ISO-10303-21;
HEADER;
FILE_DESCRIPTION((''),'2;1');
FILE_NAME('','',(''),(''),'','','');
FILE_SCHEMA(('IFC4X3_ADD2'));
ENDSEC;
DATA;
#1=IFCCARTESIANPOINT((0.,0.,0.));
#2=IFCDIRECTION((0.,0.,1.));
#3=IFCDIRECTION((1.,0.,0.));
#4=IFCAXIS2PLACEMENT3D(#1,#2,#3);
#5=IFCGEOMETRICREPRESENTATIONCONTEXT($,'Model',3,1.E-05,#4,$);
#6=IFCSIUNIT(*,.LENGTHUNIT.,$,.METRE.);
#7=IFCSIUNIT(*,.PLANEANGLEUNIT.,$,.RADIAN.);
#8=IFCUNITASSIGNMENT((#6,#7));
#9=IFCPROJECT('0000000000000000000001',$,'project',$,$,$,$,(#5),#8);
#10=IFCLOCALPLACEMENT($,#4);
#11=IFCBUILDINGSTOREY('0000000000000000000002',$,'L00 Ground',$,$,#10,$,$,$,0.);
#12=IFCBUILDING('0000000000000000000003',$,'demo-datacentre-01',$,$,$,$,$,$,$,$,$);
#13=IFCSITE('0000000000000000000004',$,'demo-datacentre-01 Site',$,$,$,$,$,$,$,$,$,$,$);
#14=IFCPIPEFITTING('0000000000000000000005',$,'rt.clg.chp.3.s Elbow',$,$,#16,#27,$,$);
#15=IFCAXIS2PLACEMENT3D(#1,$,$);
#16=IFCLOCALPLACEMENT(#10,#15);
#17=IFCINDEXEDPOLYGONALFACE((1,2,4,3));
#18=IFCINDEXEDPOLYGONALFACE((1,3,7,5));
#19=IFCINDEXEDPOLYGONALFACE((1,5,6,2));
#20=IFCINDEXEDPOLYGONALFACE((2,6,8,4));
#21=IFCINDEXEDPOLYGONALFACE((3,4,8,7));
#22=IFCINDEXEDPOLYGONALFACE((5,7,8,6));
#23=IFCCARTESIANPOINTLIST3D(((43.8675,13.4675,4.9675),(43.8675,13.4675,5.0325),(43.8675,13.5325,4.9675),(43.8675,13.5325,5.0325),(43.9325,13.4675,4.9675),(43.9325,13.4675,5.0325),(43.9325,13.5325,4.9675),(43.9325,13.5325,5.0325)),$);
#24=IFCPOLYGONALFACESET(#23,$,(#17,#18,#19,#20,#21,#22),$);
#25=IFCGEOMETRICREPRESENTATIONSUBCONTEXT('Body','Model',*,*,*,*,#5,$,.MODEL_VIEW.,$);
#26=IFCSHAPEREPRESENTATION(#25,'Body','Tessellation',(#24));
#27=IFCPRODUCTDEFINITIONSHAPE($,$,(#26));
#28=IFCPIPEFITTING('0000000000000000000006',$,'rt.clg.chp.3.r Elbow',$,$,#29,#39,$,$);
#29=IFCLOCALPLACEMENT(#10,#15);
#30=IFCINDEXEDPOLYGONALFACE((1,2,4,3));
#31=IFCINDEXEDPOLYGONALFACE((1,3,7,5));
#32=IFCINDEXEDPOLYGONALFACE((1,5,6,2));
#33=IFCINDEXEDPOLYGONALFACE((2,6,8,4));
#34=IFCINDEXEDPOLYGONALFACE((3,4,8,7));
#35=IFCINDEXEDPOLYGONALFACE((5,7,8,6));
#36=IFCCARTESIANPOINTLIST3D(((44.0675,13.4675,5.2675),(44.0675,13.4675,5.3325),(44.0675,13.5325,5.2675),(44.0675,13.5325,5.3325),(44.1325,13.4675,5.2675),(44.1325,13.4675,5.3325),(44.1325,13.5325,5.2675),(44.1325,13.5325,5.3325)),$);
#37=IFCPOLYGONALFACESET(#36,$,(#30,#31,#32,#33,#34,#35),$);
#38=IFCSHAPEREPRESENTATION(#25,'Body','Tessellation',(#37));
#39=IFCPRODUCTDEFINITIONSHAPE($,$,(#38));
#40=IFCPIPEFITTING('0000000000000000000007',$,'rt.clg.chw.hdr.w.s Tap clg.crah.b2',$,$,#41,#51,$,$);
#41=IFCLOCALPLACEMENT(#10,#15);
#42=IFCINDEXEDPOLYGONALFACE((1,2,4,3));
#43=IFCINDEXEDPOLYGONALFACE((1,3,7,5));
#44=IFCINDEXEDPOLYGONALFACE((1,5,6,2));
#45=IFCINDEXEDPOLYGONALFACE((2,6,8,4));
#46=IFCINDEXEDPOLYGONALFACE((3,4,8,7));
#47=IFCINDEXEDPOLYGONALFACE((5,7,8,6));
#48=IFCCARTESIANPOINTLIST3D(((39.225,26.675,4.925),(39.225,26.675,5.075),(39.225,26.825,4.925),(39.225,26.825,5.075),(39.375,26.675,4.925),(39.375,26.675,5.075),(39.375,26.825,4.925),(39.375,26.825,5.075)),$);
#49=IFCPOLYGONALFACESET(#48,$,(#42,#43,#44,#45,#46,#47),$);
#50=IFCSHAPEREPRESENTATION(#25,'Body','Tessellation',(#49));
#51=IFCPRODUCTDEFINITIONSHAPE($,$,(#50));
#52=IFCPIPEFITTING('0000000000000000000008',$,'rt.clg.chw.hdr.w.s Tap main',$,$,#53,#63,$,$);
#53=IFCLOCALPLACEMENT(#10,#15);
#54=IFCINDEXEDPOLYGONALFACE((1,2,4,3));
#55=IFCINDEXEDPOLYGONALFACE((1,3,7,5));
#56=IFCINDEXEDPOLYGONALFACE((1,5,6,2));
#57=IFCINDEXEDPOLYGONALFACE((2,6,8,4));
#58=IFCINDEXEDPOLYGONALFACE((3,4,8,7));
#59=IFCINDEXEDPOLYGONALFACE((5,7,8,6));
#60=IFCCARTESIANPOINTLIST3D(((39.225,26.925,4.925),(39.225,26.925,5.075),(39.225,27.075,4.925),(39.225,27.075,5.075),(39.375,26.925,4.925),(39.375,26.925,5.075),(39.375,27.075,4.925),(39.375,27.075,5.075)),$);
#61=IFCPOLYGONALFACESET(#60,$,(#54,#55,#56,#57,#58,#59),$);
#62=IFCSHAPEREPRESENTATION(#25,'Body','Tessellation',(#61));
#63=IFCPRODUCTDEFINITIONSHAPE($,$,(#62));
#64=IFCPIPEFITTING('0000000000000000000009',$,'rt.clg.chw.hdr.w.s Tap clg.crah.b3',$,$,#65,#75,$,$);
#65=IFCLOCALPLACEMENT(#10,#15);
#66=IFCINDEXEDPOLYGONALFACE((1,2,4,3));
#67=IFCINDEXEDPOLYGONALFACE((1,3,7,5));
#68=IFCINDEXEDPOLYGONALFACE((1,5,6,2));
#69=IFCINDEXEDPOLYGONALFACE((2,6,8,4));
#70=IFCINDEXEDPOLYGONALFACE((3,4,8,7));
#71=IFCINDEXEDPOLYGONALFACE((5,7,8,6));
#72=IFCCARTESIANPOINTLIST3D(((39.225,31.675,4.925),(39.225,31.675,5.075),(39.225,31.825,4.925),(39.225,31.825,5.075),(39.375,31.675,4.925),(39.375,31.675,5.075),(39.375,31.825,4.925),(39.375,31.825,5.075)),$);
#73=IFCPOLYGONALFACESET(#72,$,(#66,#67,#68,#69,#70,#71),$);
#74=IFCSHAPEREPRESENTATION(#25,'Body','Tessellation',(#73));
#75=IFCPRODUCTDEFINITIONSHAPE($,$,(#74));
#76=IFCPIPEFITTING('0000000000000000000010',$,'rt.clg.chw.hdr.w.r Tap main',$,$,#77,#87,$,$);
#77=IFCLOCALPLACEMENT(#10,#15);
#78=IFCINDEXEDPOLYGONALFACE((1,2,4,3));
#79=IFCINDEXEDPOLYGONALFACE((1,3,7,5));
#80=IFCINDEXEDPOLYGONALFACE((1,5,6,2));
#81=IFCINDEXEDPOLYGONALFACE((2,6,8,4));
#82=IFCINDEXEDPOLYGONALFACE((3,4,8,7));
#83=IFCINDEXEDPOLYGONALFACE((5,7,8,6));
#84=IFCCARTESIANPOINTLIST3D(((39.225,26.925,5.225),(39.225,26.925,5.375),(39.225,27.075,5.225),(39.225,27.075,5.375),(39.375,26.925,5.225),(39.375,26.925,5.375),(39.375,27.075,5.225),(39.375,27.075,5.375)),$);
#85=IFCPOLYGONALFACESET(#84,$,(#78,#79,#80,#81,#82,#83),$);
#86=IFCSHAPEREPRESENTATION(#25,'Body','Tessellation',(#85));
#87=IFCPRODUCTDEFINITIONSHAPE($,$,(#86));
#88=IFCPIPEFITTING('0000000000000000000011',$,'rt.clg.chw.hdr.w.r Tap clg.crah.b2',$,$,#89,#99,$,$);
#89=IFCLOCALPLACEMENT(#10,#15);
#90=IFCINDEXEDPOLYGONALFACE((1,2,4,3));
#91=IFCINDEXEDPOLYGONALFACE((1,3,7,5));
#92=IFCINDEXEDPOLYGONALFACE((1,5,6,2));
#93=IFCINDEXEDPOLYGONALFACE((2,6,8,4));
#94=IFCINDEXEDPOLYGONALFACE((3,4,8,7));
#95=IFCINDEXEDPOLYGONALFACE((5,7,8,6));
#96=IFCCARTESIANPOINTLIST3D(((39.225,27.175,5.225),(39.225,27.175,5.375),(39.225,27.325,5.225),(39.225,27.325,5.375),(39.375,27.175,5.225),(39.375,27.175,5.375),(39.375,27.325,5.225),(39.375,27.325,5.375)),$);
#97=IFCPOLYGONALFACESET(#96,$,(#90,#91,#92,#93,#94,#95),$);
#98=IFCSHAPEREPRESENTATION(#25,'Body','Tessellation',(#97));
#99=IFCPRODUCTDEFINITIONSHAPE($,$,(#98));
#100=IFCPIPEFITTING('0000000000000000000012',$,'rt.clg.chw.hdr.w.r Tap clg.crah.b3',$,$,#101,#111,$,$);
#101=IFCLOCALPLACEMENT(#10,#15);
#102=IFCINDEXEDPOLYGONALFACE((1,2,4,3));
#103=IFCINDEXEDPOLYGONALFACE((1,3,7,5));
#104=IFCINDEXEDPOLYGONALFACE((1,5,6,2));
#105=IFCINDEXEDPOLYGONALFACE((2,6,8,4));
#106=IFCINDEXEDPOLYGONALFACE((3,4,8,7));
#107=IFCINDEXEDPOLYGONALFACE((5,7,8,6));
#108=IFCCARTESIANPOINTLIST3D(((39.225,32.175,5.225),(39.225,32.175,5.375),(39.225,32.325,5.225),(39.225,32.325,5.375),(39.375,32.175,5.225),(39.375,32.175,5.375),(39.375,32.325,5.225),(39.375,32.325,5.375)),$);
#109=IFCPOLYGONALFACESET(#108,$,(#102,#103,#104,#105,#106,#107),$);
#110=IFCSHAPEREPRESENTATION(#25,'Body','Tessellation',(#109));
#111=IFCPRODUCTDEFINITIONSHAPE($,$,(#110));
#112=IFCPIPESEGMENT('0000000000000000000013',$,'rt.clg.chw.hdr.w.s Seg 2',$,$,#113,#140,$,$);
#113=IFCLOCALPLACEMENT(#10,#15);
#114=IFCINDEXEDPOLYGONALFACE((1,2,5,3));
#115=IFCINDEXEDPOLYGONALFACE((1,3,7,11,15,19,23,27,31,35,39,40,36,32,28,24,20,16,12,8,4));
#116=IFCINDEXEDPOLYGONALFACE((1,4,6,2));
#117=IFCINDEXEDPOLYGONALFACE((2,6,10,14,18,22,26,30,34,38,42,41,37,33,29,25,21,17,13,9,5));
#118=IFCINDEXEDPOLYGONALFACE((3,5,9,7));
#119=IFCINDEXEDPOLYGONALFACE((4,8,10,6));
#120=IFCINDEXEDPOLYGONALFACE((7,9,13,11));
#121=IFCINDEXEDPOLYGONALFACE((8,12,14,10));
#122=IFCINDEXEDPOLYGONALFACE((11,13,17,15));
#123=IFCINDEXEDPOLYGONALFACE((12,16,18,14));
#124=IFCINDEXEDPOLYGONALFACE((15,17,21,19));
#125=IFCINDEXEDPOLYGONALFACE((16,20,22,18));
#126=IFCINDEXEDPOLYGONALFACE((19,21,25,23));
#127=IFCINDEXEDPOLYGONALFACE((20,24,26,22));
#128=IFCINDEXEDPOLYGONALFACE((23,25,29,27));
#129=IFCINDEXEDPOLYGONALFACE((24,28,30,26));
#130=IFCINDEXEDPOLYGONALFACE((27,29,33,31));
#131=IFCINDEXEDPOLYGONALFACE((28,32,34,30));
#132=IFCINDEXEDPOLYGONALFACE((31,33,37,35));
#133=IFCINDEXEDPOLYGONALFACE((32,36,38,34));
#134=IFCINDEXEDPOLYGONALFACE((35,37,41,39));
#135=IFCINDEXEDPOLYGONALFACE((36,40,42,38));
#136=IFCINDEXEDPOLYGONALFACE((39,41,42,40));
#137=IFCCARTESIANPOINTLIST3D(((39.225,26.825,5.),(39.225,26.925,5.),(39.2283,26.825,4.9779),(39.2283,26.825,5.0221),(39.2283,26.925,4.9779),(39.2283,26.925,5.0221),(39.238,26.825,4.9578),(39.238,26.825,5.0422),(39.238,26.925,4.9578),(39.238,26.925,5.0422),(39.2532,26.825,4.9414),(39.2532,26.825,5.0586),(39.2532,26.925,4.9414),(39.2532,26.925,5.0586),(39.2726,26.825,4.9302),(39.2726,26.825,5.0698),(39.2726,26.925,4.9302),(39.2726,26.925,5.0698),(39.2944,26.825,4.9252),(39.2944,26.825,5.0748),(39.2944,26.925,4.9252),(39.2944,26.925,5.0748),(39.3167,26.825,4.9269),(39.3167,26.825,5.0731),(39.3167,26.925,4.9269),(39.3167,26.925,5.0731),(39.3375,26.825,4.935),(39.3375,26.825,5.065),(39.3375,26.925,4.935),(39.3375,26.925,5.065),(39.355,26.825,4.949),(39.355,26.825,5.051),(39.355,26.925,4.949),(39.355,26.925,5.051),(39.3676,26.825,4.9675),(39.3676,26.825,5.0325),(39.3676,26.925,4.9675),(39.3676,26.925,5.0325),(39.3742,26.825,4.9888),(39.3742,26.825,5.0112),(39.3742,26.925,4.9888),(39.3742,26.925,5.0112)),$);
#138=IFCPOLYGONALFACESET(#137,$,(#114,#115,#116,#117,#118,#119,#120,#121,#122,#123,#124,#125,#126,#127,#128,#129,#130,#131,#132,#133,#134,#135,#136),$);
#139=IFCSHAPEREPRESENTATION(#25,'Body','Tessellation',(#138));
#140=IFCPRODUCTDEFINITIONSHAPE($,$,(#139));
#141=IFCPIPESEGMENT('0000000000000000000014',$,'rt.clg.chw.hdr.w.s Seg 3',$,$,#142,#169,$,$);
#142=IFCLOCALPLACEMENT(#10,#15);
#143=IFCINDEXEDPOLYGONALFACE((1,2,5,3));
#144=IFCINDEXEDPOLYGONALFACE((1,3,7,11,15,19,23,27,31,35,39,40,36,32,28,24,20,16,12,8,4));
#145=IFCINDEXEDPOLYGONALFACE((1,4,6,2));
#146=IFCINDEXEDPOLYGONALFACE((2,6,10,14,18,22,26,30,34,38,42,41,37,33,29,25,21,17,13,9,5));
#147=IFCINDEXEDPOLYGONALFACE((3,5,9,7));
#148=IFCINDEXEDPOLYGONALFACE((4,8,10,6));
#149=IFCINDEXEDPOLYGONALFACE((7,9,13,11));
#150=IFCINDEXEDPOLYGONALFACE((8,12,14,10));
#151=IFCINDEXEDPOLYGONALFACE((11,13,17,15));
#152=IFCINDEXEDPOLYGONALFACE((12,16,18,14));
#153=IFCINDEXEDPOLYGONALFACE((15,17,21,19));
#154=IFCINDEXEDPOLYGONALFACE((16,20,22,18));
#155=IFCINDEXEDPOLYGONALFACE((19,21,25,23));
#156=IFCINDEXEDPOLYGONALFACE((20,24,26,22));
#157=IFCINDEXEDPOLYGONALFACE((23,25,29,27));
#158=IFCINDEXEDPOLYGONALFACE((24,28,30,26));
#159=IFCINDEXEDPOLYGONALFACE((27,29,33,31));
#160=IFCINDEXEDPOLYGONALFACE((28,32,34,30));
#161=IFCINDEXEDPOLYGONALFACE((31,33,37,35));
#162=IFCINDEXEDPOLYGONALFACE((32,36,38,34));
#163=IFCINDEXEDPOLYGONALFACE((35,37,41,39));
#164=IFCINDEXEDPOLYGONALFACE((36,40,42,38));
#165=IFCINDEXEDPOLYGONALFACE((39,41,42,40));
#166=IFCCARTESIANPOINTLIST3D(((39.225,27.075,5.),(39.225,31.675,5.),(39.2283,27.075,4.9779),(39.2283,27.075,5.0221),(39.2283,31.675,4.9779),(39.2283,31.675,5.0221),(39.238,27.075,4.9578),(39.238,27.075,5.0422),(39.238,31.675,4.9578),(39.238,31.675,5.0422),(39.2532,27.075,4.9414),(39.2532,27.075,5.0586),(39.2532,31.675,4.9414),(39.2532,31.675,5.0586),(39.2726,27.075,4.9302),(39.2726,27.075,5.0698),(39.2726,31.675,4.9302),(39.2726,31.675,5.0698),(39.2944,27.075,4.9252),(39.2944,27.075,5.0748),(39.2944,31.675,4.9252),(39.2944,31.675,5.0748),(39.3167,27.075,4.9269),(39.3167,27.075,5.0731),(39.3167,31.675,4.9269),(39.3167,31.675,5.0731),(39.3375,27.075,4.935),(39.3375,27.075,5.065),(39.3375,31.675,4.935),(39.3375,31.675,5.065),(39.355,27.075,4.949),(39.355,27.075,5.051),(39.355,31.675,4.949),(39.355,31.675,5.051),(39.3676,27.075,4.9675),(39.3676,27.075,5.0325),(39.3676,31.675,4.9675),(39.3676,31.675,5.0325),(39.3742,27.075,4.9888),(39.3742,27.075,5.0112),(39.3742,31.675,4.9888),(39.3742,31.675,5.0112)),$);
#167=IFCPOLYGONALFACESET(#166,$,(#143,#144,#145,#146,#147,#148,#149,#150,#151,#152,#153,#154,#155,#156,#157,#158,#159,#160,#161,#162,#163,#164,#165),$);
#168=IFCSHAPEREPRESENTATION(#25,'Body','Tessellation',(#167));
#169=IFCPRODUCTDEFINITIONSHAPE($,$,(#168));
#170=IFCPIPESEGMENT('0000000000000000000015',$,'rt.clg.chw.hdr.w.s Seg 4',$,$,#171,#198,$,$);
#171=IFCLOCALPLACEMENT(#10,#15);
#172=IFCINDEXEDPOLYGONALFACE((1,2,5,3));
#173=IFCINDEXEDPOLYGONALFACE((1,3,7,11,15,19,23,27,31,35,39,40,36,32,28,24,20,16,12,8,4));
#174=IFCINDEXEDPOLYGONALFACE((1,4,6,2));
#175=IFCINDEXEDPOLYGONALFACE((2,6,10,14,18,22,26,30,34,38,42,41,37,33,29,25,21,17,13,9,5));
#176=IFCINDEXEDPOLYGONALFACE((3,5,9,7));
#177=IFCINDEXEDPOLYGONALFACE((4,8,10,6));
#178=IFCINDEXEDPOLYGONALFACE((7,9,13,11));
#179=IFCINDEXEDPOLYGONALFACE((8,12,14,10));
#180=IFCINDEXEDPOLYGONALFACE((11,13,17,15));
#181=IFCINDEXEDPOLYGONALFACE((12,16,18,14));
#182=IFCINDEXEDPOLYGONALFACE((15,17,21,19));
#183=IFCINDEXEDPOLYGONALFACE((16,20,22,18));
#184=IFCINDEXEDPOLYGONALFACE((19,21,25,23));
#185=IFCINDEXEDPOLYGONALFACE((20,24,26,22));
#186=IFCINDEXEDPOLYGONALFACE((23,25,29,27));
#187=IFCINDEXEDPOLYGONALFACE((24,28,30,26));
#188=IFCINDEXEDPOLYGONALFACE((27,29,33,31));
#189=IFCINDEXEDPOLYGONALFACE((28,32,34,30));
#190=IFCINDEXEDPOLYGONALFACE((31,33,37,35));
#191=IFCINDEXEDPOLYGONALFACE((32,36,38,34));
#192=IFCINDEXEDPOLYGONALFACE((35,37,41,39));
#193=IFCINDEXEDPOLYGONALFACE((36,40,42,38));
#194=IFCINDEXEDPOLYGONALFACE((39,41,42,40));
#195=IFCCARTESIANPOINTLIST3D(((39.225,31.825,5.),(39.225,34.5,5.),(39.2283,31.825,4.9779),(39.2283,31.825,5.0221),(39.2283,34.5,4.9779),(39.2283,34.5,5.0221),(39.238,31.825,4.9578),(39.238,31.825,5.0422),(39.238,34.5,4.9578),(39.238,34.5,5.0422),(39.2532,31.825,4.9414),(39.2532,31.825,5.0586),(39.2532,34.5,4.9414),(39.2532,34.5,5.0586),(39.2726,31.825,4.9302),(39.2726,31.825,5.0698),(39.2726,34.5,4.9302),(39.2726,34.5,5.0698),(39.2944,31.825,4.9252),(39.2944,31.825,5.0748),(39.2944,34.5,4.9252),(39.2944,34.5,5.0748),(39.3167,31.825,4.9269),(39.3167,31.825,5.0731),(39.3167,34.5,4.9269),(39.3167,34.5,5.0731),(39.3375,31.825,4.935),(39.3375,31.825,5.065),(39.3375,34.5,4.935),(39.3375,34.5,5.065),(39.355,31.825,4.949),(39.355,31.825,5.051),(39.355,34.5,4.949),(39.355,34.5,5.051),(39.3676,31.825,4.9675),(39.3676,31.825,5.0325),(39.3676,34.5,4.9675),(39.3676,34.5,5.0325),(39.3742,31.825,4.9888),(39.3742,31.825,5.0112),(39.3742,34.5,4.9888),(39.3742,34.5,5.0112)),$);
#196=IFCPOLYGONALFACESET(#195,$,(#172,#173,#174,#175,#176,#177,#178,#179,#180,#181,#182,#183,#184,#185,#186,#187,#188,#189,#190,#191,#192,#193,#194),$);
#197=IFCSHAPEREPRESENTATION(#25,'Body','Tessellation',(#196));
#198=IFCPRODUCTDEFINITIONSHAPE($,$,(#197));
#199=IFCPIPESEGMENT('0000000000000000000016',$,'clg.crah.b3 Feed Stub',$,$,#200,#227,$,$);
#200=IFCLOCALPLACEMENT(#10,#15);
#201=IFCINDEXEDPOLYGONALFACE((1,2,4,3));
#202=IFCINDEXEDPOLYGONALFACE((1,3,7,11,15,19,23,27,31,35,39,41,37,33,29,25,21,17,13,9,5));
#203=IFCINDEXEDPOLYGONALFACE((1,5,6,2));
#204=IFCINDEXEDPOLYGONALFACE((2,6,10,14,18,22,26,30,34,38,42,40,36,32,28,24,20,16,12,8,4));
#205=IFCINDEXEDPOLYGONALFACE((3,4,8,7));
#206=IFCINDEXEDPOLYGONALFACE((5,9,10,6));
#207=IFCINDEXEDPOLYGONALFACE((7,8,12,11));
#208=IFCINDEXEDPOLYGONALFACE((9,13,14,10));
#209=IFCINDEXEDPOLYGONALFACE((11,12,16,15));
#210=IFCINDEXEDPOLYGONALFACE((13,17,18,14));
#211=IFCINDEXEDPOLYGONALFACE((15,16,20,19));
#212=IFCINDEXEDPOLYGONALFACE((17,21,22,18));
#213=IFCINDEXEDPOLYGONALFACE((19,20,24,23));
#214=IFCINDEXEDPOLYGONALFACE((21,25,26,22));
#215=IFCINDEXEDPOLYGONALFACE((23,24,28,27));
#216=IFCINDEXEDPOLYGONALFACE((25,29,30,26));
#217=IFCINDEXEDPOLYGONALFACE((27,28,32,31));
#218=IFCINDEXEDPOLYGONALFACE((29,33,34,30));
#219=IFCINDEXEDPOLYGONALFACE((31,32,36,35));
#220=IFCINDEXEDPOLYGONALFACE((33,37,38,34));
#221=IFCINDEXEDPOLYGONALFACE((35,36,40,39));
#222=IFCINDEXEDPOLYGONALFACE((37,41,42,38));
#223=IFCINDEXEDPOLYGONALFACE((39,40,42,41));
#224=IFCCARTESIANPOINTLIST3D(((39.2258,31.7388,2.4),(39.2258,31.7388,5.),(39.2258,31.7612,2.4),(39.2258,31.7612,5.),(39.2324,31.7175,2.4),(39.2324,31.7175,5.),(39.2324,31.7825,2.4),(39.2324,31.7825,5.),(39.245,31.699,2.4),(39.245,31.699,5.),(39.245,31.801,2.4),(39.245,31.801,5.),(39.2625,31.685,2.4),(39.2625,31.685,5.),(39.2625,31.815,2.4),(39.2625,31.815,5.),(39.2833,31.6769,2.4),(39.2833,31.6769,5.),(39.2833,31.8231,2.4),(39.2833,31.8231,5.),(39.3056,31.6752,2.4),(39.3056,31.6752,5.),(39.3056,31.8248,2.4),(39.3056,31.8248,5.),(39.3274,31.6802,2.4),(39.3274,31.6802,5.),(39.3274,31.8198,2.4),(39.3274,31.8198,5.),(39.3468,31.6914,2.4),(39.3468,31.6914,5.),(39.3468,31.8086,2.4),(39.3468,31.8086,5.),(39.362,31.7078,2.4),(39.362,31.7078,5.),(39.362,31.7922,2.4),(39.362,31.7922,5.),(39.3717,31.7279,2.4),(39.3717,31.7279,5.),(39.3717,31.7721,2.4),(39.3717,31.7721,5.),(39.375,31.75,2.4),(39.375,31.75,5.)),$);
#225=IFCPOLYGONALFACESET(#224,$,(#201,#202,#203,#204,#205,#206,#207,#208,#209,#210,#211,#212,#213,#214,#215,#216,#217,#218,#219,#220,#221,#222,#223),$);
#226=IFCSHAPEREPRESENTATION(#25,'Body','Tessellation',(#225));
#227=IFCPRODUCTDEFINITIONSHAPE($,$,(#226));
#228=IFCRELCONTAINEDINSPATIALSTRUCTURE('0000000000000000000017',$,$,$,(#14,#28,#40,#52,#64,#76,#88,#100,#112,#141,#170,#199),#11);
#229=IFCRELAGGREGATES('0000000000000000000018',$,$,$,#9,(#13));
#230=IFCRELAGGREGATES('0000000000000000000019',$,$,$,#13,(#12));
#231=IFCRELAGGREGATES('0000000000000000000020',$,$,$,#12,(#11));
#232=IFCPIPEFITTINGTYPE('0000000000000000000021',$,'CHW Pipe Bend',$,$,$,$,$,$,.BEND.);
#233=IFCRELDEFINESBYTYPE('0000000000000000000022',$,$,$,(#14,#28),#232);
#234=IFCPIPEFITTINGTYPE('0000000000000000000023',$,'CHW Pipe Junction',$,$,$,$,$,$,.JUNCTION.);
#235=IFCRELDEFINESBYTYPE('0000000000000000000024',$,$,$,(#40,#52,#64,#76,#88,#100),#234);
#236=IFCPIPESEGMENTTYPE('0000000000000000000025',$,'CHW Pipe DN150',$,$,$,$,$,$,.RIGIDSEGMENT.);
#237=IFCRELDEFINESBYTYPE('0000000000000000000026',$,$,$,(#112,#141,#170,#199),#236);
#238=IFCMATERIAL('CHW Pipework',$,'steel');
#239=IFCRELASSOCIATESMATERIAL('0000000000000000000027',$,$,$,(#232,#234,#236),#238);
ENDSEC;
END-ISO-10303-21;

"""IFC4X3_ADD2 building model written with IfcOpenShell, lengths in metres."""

from ifc_helpers import new_model, si_unit, frame, origin_with_axes, place, context, subcontext, project, spatial, rectangle, circle, extrude, material, type_object, element, save


model = new_model("IFC4X3_ADD2")

# Units and contexts
model_context = context("Model", 3, precision=1e-05, world=origin_with_axes())
body_context = subcontext(model_context, "Body", "Model", "MODEL_VIEW")
ifc_project = project(units=[si_unit("LENGTHUNIT", "METRE"), si_unit("PLANEANGLEUNIT", "RADIAN")], contexts=[model_context])

# Site, building, storey
site = spatial("IfcSite", under=ifc_project, Name="demo-datacentre-01 Site")
building = spatial("IfcBuilding", under=site, Name="demo-datacentre-01")
storey_placement = place(None, origin_with_axes())
storey = spatial("IfcBuildingStorey", under=building, at=storey_placement, Name="L00 Ground", Elevation=0.0)

# Pipe fittings
ifc_material = material(Name="CHW Pipework", Category="steel")
pipe_fitting_type_1 = type_object("IfcPipeFittingType", Name="CHW Pipe Bend", PredefinedType="BEND", material=ifc_material)
for number, where, z_axis, x_axis, name in (
    (1, (43.9, 13.5, 4.9675), (0.0, 0.0, 1.0), (1.0, 0.0, 0.0), "rt.clg.chp.3.s Elbow"),
    (2, (44.1, 13.5, 5.2675), (0.0, 0.0, 1.0), (1.0, 0.0, 0.0), "rt.clg.chp.3.r Elbow"),
):
    element("IfcPipeFitting", number, at=place(storey_placement, frame(where, z_axis=z_axis, x_axis=x_axis)), inside=storey, type_object=pipe_fitting_type_1, Name=name, context=body_context, shape_type="SweptSolid", body=[
        extrude(rectangle(XDim=0.065, YDim=0.065), origin_with_axes(), (0.0, 0.0, 1.0), 0.065),
    ])
pipe_fitting_type_2 = type_object("IfcPipeFittingType", Name="CHW Pipe Junction", PredefinedType="JUNCTION", material=ifc_material)
for number, where, z_axis, x_axis, name in (
    (3, (39.3, 26.75, 4.925), (0.0, 0.0, 1.0), (1.0, 0.0, 0.0), "rt.clg.chw.hdr.w.s Tap clg.crah.b2"),
    (4, (39.3, 27.0, 4.925), (0.0, 0.0, 1.0), (1.0, 0.0, 0.0), "rt.clg.chw.hdr.w.s Tap main"),
    (5, (39.3, 31.75, 4.925), (0.0, 0.0, 1.0), (1.0, 0.0, 0.0), "rt.clg.chw.hdr.w.s Tap clg.crah.b3"),
    (6, (39.3, 27.0, 5.225), (0.0, 0.0, 1.0), (1.0, 0.0, 0.0), "rt.clg.chw.hdr.w.r Tap main"),
    (7, (39.3, 27.25, 5.225), (0.0, 0.0, 1.0), (1.0, 0.0, 0.0), "rt.clg.chw.hdr.w.r Tap clg.crah.b2"),
    (8, (39.3, 32.25, 5.225), (0.0, 0.0, 1.0), (1.0, 0.0, 0.0), "rt.clg.chw.hdr.w.r Tap clg.crah.b3"),
):
    element("IfcPipeFitting", number, at=place(storey_placement, frame(where, z_axis=z_axis, x_axis=x_axis)), inside=storey, type_object=pipe_fitting_type_2, Name=name, context=body_context, shape_type="SweptSolid", body=[
        extrude(rectangle(XDim=0.15, YDim=0.15), origin_with_axes(), (0.0, 0.0, 1.0), 0.15),
    ])

# Pipe segments
pipe_segment_type_1 = type_object("IfcPipeSegmentType", Name="CHW Pipe DN150", PredefinedType="RIGIDSEGMENT", material=ifc_material)
pipe_segment_1_placement = place(storey_placement, frame((39.3, 26.825, 5.0), z_axis=(0.0, 1.0, 0.0), x_axis=(-1.0, 0.0, 0.0)))
element("IfcPipeSegment", 9, at=pipe_segment_1_placement, inside=storey, type_object=pipe_segment_type_1, Name="rt.clg.chw.hdr.w.s Seg 2", context=body_context, shape_type="SweptSolid", body=[
    extrude(circle(Radius=0.075), origin_with_axes(), (0.0, 0.0, 1.0), 0.1),
])
pipe_segment_2_placement = place(storey_placement, frame((39.3, 27.075, 5.0), z_axis=(0.0, 1.0, 0.0), x_axis=(-1.0, 0.0, 0.0)))
element("IfcPipeSegment", 10, at=pipe_segment_2_placement, inside=storey, type_object=pipe_segment_type_1, Name="rt.clg.chw.hdr.w.s Seg 3", context=body_context, shape_type="SweptSolid", body=[
    extrude(circle(Radius=0.075), origin_with_axes(), (0.0, 0.0, 1.0), 4.6),
])
pipe_segment_3_placement = place(storey_placement, frame((39.3, 31.825, 5.0), z_axis=(0.0, 1.0, 0.0), x_axis=(-1.0, 0.0, 0.0)))
element("IfcPipeSegment", 11, at=pipe_segment_3_placement, inside=storey, type_object=pipe_segment_type_1, Name="rt.clg.chw.hdr.w.s Seg 4", context=body_context, shape_type="SweptSolid", body=[
    extrude(circle(Radius=0.075), origin_with_axes(), (0.0, 0.0, 1.0), 2.675),
])
pipe_segment_4_placement = place(storey_placement, frame((39.3, 31.75, 5.0), z_axis=(0.0, 0.0, -1.0), x_axis=(1.0, 0.0, 0.0)))
element("IfcPipeSegment", 12, at=pipe_segment_4_placement, inside=storey, type_object=pipe_segment_type_1, Name="clg.crah.b3 Feed Stub", context=body_context, shape_type="SweptSolid", body=[
    extrude(circle(Radius=0.075), origin_with_axes(), (0.0, 0.0, 1.0), 2.6),
])

save(model, "model.ifc")
